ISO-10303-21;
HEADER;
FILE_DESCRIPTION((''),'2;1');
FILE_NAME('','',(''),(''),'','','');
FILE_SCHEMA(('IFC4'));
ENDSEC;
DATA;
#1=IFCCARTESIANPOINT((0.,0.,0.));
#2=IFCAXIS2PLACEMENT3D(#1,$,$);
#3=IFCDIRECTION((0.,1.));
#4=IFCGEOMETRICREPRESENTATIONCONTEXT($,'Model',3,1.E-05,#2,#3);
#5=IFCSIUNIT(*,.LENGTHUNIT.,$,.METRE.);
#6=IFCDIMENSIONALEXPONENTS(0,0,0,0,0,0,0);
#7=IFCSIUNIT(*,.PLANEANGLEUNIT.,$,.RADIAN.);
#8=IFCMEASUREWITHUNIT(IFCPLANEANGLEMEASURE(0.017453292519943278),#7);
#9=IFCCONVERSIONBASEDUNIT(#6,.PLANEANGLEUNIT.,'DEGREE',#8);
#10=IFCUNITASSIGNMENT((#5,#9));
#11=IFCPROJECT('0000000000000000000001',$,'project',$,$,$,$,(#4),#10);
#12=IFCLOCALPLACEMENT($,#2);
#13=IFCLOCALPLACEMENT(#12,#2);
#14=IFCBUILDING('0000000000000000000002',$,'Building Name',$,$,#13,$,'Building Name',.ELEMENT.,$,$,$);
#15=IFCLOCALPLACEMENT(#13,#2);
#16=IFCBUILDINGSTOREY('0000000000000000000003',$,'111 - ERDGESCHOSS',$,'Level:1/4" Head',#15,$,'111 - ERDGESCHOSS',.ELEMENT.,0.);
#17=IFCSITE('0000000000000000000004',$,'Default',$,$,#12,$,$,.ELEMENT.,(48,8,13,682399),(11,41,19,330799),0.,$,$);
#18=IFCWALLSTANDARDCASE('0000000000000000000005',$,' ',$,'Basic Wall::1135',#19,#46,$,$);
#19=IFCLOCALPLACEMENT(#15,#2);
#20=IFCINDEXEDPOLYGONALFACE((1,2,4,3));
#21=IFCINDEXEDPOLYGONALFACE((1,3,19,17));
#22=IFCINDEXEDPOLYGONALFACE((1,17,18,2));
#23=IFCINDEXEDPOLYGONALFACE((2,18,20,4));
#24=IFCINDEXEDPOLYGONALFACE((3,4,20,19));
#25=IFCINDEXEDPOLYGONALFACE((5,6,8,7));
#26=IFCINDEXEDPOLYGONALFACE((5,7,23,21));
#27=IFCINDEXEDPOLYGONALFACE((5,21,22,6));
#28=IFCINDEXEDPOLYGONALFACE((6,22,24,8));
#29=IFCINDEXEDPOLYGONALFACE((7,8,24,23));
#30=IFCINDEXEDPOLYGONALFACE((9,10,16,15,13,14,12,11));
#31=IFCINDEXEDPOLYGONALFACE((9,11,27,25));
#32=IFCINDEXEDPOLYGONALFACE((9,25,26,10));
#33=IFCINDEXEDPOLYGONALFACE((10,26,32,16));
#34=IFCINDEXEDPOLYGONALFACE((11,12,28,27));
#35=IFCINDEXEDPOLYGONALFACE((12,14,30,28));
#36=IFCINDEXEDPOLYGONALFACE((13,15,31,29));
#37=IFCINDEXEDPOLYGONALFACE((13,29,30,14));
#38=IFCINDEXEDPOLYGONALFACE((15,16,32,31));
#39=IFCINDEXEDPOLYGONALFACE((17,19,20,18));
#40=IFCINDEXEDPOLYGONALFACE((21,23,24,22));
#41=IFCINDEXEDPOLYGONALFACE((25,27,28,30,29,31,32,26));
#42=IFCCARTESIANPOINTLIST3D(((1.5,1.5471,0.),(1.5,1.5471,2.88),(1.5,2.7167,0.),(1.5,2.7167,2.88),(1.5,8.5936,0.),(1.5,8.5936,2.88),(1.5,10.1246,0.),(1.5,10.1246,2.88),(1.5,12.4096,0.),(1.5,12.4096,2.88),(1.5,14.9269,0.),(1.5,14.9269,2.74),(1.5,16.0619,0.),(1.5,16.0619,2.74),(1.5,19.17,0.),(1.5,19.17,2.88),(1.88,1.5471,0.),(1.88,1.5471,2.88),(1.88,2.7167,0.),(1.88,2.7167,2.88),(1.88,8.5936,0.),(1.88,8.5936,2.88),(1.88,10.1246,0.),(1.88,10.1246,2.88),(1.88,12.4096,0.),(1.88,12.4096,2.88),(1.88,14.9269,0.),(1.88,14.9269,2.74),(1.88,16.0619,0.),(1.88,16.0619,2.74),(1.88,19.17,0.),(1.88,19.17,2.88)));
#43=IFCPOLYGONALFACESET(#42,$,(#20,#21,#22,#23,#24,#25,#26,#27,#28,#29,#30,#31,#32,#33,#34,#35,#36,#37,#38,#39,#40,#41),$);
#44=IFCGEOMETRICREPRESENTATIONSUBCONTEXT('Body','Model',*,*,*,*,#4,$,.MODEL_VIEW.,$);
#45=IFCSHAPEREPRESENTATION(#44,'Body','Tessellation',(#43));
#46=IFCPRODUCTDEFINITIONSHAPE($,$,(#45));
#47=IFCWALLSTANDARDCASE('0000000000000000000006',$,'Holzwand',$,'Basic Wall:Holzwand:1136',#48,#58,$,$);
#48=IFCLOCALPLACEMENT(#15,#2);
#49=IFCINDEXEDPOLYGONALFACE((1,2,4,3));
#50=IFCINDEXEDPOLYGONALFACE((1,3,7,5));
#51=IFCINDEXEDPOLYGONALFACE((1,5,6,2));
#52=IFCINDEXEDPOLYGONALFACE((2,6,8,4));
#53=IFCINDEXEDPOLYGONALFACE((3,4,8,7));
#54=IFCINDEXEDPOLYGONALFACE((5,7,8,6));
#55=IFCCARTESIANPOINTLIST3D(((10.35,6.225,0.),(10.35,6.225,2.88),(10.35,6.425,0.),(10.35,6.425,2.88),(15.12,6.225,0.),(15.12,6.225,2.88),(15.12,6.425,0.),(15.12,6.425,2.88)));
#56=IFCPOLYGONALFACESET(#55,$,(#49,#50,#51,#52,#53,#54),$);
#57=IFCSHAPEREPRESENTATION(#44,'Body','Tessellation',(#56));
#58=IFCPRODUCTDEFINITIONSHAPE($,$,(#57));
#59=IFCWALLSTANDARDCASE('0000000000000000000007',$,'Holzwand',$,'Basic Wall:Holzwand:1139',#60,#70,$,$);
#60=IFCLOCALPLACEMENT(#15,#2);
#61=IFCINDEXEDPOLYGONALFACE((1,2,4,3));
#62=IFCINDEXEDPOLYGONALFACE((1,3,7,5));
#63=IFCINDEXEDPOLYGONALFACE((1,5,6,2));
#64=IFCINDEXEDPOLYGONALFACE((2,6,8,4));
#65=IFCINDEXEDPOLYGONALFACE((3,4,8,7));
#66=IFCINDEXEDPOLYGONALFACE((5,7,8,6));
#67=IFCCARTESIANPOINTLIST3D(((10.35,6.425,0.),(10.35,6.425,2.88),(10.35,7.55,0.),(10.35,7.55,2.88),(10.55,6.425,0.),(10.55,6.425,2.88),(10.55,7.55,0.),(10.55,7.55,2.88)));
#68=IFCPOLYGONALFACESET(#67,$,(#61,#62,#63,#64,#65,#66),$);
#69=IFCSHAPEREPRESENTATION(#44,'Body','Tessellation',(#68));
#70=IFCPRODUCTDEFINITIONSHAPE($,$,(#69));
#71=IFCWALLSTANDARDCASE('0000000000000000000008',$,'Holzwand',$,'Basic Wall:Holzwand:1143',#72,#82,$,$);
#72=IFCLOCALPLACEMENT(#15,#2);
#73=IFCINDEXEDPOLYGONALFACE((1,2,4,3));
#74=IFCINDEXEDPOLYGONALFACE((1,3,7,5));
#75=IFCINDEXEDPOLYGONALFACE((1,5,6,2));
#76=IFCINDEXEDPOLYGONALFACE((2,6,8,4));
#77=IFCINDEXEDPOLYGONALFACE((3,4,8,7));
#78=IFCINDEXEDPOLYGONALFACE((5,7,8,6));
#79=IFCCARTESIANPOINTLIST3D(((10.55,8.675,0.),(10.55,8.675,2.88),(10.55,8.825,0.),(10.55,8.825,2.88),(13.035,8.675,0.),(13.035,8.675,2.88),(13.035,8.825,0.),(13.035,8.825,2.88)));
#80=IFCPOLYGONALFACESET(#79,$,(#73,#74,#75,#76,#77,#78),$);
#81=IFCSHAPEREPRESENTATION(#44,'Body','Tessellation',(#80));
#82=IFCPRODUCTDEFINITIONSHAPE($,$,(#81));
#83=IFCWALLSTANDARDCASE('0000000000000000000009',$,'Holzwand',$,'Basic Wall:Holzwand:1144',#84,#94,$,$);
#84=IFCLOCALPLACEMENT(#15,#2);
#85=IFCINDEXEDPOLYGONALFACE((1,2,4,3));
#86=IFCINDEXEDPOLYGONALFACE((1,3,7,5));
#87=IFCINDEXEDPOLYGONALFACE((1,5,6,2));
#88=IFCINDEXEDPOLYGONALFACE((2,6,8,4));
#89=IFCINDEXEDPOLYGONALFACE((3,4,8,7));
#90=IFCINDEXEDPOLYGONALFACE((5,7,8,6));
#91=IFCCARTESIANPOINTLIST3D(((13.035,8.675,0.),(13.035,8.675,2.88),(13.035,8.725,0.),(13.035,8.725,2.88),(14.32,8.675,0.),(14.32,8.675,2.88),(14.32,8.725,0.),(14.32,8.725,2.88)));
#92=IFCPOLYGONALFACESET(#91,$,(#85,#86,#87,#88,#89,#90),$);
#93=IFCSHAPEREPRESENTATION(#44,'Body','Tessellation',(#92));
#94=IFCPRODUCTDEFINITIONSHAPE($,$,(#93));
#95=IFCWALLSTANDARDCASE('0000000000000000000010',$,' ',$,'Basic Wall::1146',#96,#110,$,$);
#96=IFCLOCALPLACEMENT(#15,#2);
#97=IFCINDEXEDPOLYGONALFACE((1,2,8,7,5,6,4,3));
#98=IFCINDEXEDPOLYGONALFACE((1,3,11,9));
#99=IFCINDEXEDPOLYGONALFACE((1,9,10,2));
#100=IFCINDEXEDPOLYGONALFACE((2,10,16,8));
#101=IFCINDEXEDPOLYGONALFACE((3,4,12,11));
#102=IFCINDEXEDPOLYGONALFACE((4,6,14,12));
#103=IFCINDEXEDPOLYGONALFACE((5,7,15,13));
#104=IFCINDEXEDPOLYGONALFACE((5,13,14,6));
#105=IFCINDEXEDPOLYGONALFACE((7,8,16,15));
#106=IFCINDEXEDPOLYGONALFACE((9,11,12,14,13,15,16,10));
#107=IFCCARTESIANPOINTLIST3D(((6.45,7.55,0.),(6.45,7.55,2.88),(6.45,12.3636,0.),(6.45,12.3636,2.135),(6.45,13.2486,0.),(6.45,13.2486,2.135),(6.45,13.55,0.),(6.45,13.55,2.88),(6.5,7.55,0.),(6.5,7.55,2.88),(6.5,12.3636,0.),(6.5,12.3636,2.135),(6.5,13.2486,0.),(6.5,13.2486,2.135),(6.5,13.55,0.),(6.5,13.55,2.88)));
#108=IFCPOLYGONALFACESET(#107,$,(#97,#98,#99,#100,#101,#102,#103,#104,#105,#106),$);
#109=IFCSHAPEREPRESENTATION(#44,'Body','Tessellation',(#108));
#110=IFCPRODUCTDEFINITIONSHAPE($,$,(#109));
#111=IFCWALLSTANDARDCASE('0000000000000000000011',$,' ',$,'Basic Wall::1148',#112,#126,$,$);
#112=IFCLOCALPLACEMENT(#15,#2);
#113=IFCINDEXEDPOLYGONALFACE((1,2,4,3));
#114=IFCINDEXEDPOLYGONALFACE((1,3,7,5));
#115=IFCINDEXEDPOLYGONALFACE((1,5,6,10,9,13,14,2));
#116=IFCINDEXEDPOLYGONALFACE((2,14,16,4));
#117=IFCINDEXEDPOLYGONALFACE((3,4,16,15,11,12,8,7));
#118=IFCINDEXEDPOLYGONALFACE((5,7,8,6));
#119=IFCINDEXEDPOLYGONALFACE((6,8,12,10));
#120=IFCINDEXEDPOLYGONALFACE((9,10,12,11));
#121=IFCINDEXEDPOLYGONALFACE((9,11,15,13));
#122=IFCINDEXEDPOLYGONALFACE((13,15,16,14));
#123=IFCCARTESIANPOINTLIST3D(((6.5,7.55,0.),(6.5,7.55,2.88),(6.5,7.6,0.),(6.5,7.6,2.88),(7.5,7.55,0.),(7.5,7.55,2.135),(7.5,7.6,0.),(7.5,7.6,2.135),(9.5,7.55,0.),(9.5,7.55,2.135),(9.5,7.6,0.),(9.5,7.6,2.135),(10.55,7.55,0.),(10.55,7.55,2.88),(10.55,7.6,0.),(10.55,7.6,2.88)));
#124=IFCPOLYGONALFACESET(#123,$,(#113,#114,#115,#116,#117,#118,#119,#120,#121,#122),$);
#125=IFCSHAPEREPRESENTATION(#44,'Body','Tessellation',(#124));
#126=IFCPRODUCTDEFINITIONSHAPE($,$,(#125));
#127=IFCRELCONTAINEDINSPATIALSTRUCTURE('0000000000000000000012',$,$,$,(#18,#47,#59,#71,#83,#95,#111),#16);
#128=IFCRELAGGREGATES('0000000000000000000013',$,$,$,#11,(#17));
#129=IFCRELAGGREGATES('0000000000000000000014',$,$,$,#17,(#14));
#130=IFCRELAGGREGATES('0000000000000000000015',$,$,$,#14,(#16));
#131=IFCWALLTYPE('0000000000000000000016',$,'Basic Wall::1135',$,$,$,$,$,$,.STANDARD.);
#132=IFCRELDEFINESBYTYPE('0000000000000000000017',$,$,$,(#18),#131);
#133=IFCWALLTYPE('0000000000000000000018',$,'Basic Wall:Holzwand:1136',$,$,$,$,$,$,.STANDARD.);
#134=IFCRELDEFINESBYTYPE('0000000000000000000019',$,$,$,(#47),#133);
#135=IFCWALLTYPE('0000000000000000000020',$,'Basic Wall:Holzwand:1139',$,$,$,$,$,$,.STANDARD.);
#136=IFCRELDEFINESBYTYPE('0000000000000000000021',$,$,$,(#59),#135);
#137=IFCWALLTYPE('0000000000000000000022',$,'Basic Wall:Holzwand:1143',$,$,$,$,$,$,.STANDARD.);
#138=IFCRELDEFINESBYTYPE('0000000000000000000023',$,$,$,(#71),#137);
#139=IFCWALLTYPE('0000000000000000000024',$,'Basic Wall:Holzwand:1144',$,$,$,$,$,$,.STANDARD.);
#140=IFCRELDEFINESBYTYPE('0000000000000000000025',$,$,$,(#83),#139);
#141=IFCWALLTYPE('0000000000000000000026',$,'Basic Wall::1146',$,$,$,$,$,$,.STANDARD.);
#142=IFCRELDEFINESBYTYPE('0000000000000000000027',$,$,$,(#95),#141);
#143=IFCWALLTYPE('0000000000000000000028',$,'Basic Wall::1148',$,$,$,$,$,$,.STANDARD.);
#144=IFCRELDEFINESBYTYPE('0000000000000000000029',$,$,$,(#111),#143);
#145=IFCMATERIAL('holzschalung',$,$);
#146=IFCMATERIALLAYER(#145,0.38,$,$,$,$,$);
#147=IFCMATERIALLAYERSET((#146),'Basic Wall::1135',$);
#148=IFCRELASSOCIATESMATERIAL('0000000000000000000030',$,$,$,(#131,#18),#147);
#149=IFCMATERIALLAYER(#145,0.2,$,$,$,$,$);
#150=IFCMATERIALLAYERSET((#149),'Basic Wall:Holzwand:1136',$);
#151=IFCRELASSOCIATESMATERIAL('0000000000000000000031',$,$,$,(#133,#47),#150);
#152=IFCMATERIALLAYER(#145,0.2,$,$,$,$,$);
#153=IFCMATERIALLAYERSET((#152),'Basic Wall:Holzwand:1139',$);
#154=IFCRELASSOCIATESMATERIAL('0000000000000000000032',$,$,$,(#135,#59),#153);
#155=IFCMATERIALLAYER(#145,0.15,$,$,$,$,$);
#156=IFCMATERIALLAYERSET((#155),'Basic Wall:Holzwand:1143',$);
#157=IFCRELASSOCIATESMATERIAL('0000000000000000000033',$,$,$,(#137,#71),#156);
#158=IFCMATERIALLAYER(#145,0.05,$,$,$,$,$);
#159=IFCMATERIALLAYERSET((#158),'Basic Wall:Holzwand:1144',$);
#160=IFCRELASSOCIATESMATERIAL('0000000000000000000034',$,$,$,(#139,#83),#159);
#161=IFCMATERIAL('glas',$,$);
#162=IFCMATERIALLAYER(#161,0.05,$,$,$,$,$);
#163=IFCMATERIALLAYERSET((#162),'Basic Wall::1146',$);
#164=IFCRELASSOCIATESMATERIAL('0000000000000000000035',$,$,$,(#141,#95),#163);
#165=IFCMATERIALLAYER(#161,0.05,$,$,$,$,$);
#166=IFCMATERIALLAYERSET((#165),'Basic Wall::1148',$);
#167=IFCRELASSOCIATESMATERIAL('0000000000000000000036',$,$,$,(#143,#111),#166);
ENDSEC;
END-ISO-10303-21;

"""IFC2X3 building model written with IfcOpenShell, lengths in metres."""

from ifc_helpers import new_model, entity, si_unit, converted_unit, direction, frame, frame_2d, origin, place, context, subcontext, project, spatial, rectangle, extrude, material, layer, layer_set, layer_usage, type_object, element, save


model = new_model("IFC2X3")

# Units and contexts
model_context = context("Model", 3, precision=1e-05, world=origin(), true_north=direction((0.0, 1.0)))
body_context = subcontext(model_context, "Body", "Model", "MODEL_VIEW")
ifc_project = project(units=[si_unit("LENGTHUNIT", "METRE"), converted_unit("PLANEANGLEUNIT", "DEGREE", entity("IfcPlaneAngleMeasure", 0.017453292519943278), si_unit("PLANEANGLEUNIT", "RADIAN"), dimensions=[0, 0, 0, 0, 0, 0, 0])], contexts=[model_context])

# Site, building, storey
site_placement = place(None, origin())
site = spatial("IfcSite", under=ifc_project, at=site_placement, Name="Default", CompositionType="ELEMENT", RefLatitude=(48, 8, 13, 682399), RefLongitude=(11, 41, 19, 330799), RefElevation=0.0)
building_placement = place(site_placement, origin())
building = spatial("IfcBuilding", under=site, at=building_placement, Name="Building Name", LongName="Building Name", CompositionType="ELEMENT")
storey_placement = place(building_placement, origin())
storey = spatial("IfcBuildingStorey", under=building, at=storey_placement, Name="111 - ERDGESCHOSS", ObjectType="Level:1/4\" Head", LongName="111 - ERDGESCHOSS", CompositionType="ELEMENT", Elevation=0.0)

# Wall, openings
ifc_material_1 = material(Name="holzschalung")
ifc_layer_1 = layer(ifc_material_1, 0.38)
ifc_layer_set_1 = layer_set([ifc_layer_1], Name="Basic Wall::1135")
ifc_layer_usage_1 = layer_usage(ifc_layer_set_1, "AXIS2", "NEGATIVE", 0.19)
wall_type_1 = type_object("IfcWallType", Name="Basic Wall::1135", PredefinedType="STANDARD", material=ifc_layer_set_1)
wall_1_placement = place(storey_placement, frame((1.69, 1.5471, 0.0), z_axis=(0.0, 0.0, 1.0), x_axis=(0.0, 1.0, 0.0)))
wall_1 = element("IfcWallStandardCase", 1, at=wall_1_placement, inside=storey, type_object=wall_type_1, material=ifc_layer_usage_1, Name=" ", ObjectType="Basic Wall::1135", context=body_context, shape_type="SweptSolid", body=[
    extrude(rectangle(XDim=17.6229, YDim=0.38, at=frame_2d((8.8114, 0.0), x_axis=(-1.0, 0.0))), origin(), (0.0, 0.0, 1.0), 2.88),
])
opening_1_placement = place(wall_1_placement, origin())
element("IfcOpeningElement", 2, at=opening_1_placement, cuts=wall_1, ObjectType="Opening", context=body_context, shape_type="SweptSolid", body=[
    extrude(rectangle(XDim=2.88, YDim=1.135, at=frame_2d((0.0, 0.0), x_axis=(0.0, 1.0))), frame((9.145, -0.19, 1.44), z_axis=(0.0, 1.0, 0.0), x_axis=(-1.0, 0.0, 0.0)), (0.0, 0.0, 1.0), 0.38),
])
opening_2_placement = place(wall_1_placement, origin())
element("IfcOpeningElement", 3, at=opening_2_placement, cuts=wall_1, ObjectType="Opening", context=body_context, shape_type="SweptSolid", body=[
    extrude(rectangle(XDim=2.88, YDim=1.135, at=frame_2d((0.0, 0.0), x_axis=(0.0, 1.0))), frame((6.4789, -0.19, 1.44), z_axis=(0.0, 1.0, 0.0), x_axis=(-1.0, 0.0, 0.0)), (0.0, 0.0, 1.0), 0.38),
])
opening_3_placement = place(wall_1_placement, origin())
element("IfcOpeningElement", 4, at=opening_3_placement, cuts=wall_1, ObjectType="Opening", context=body_context, shape_type="SweptSolid", body=[
    extrude(rectangle(XDim=2.88, YDim=1.135, at=frame_2d((0.0, 0.0), x_axis=(0.0, 1.0))), frame((1.7371, -0.19, 1.44), z_axis=(0.0, 1.0, 0.0), x_axis=(-1.0, 0.0, 0.0)), (0.0, 0.0, 1.0), 0.38),
])
opening_4_placement = place(wall_1_placement, origin())
element("IfcOpeningElement", 5, at=opening_4_placement, cuts=wall_1, ObjectType="Opening", context=body_context, shape_type="SweptSolid", body=[
    extrude(rectangle(XDim=2.88, YDim=1.15, at=frame_2d((0.0, 0.0), x_axis=(0.0, 1.0))), frame((10.2875, -0.19, 1.44), z_axis=(0.0, 1.0, 0.0), x_axis=(-1.0, 0.0, 0.0)), (0.0, 0.0, 1.0), 0.38),
])
opening_5_placement = place(wall_1_placement, origin())
element("IfcOpeningElement", 6, at=opening_5_placement, cuts=wall_1, ObjectType="Opening", context=body_context, shape_type="SweptSolid", body=[
    extrude(rectangle(XDim=2.74, YDim=1.135, at=frame_2d((0.0, 0.0), x_axis=(0.0, 1.0))), frame((13.9473, -0.19, 1.37), z_axis=(0.0, 1.0, 0.0), x_axis=(-1.0, 0.0, 0.0)), (0.0, 0.0, 1.0), 0.38),
])
opening_6_placement = place(wall_1_placement, origin())
element("IfcOpeningElement", 7, at=opening_6_placement, cuts=wall_1, ObjectType="Opening", context=body_context, shape_type="SweptSolid", body=[
    extrude(rectangle(XDim=2.88, YDim=3.608, at=frame_2d((0.0, 0.0), x_axis=(0.0, 1.0))), frame((4.1074, -0.19, 1.44), z_axis=(0.0, 1.0, 0.0), x_axis=(-1.0, 0.0, 0.0)), (0.0, 0.0, 1.0), 0.38),
])

# Walls
ifc_layer_2 = layer(ifc_material_1, 0.2)
ifc_layer_set_2 = layer_set([ifc_layer_2], Name="Basic Wall:Holzwand:1136")
ifc_layer_usage_2 = layer_usage(ifc_layer_set_2, "AXIS2", "NEGATIVE", 0.1)
wall_type_2 = type_object("IfcWallType", Name="Basic Wall:Holzwand:1136", PredefinedType="STANDARD", material=ifc_layer_set_2)
wall_2_placement = place(storey_placement, frame((15.12, 6.325, 0.0), z_axis=(0.0, 0.0, 1.0), x_axis=(-1.0, 0.0, 0.0)))
element("IfcWallStandardCase", 8, at=wall_2_placement, inside=storey, type_object=wall_type_2, material=ifc_layer_usage_2, Name="Holzwand", ObjectType="Basic Wall:Holzwand:1136", context=body_context, shape_type="SweptSolid", body=[
    extrude(rectangle(XDim=4.77, YDim=0.2, at=frame_2d((2.385, 0.0), x_axis=(-1.0, 0.0))), origin(), (0.0, 0.0, 1.0), 2.88),
])
ifc_layer_3 = layer(ifc_material_1, 0.2)
ifc_layer_set_3 = layer_set([ifc_layer_3], Name="Basic Wall:Holzwand:1139")
ifc_layer_usage_3 = layer_usage(ifc_layer_set_3, "AXIS2", "NEGATIVE", 0.1)
wall_type_3 = type_object("IfcWallType", Name="Basic Wall:Holzwand:1139", PredefinedType="STANDARD", material=ifc_layer_set_3)
wall_3_placement = place(storey_placement, frame((10.45, 7.55, 0.0), z_axis=(0.0, 0.0, 1.0), x_axis=(0.0, -1.0, 0.0)))
element("IfcWallStandardCase", 9, at=wall_3_placement, inside=storey, type_object=wall_type_3, material=ifc_layer_usage_3, Name="Holzwand", ObjectType="Basic Wall:Holzwand:1139", context=body_context, shape_type="SweptSolid", body=[
    extrude(rectangle(XDim=1.125, YDim=0.2, at=frame_2d((0.5625, 0.0), x_axis=(-1.0, 0.0))), origin(), (0.0, 0.0, 1.0), 2.88),
])
ifc_layer_4 = layer(ifc_material_1, 0.15)
ifc_layer_set_4 = layer_set([ifc_layer_4], Name="Basic Wall:Holzwand:1143")
ifc_layer_usage_4 = layer_usage(ifc_layer_set_4, "AXIS2", "NEGATIVE", 0.075)
wall_type_4 = type_object("IfcWallType", Name="Basic Wall:Holzwand:1143", PredefinedType="STANDARD", material=ifc_layer_set_4)
wall_4_placement = place(storey_placement, frame((13.035, 8.75, 0.0), z_axis=(0.0, 0.0, 1.0), x_axis=(-1.0, 0.0, 0.0)))
element("IfcWallStandardCase", 10, at=wall_4_placement, inside=storey, type_object=wall_type_4, material=ifc_layer_usage_4, Name="Holzwand", ObjectType="Basic Wall:Holzwand:1143", context=body_context, shape_type="SweptSolid", body=[
    extrude(rectangle(XDim=2.485, YDim=0.15, at=frame_2d((1.2425, 0.0), x_axis=(-1.0, 0.0))), origin(), (0.0, 0.0, 1.0), 2.88),
])
ifc_layer_5 = layer(ifc_material_1, 0.05)
ifc_layer_set_5 = layer_set([ifc_layer_5], Name="Basic Wall:Holzwand:1144")
ifc_layer_usage_5 = layer_usage(ifc_layer_set_5, "AXIS2", "NEGATIVE", 0.025)
wall_type_5 = type_object("IfcWallType", Name="Basic Wall:Holzwand:1144", PredefinedType="STANDARD", material=ifc_layer_set_5)
wall_5_placement = place(storey_placement, frame((13.035, 8.7, 0.0)))
element("IfcWallStandardCase", 11, at=wall_5_placement, inside=storey, type_object=wall_type_5, material=ifc_layer_usage_5, Name="Holzwand", ObjectType="Basic Wall:Holzwand:1144", context=body_context, shape_type="SweptSolid", body=[
    extrude(rectangle(XDim=1.285, YDim=0.05, at=frame_2d((0.6425, 0.0), x_axis=(-1.0, 0.0))), origin(), (0.0, 0.0, 1.0), 2.88),
])

# Walls, openings
ifc_material_2 = material(Name="glas")
ifc_layer_6 = layer(ifc_material_2, 0.05)
ifc_layer_set_6 = layer_set([ifc_layer_6], Name="Basic Wall::1146")
ifc_layer_usage_6 = layer_usage(ifc_layer_set_6, "AXIS2", "NEGATIVE", 0.025)
wall_type_6 = type_object("IfcWallType", Name="Basic Wall::1146", PredefinedType="STANDARD", material=ifc_layer_set_6)
wall_6_placement = place(storey_placement, frame((6.475, 7.55, 0.0), z_axis=(0.0, 0.0, 1.0), x_axis=(0.0, 1.0, 0.0)))
wall_6 = element("IfcWallStandardCase", 12, at=wall_6_placement, inside=storey, type_object=wall_type_6, material=ifc_layer_usage_6, Name=" ", ObjectType="Basic Wall::1146", context=body_context, shape_type="SweptSolid", body=[
    extrude(rectangle(XDim=6.0, YDim=0.05, at=frame_2d((3.0, 0.0), x_axis=(-1.0, 0.0))), origin(), (0.0, 0.0, 1.0), 2.88),
])
opening_7_placement = place(wall_6_placement, frame((-7.55, 6.475, 0.0), z_axis=(0.0, 0.0, 1.0), x_axis=(0.0, -1.0, 0.0)))
element("IfcOpeningElement", 13, at=opening_7_placement, cuts=wall_6, ObjectType="Opening", context=body_context, shape_type="SweptSolid", body=[
    extrude(rectangle(XDim=2.135, YDim=0.885, at=frame_2d((0.0, 0.0), x_axis=(0.0, 1.0))), frame((6.5005, 12.8061, 1.0675), z_axis=(-1.0, 0.0, 0.0), x_axis=(0.0, -1.0, 0.0)), (0.0, 0.0, 1.0), 0.051),
])
ifc_layer_7 = layer(ifc_material_2, 0.05)
ifc_layer_set_7 = layer_set([ifc_layer_7], Name="Basic Wall::1148")
ifc_layer_usage_7 = layer_usage(ifc_layer_set_7, "AXIS2", "NEGATIVE", 0.025)
wall_type_7 = type_object("IfcWallType", Name="Basic Wall::1148", PredefinedType="STANDARD", material=ifc_layer_set_7)
wall_7_placement = place(storey_placement, frame((10.55, 7.575, 0.0), z_axis=(0.0, 0.0, 1.0), x_axis=(-1.0, 0.0, 0.0)))
wall_7 = element("IfcWallStandardCase", 14, at=wall_7_placement, inside=storey, type_object=wall_type_7, material=ifc_layer_usage_7, Name=" ", ObjectType="Basic Wall::1148", context=body_context, shape_type="SweptSolid", body=[
    extrude(rectangle(XDim=4.05, YDim=0.05, at=frame_2d((2.025, 0.0), x_axis=(1.0, 0.0))), origin(), (0.0, 0.0, 1.0), 2.88),
])
opening_8_placement = place(wall_7_placement, frame((10.55, 7.575, 0.0), z_axis=(0.0, 0.0, 1.0), x_axis=(-1.0, 0.0, 0.0)))
element("IfcOpeningElement", 15, at=opening_8_placement, cuts=wall_7, ObjectType="Opening", context=body_context, shape_type="SweptSolid", body=[
    extrude(rectangle(XDim=2.135, YDim=2.0, at=frame_2d((0.0, 0.0), x_axis=(0.0, 1.0))), frame((8.5, 7.6005, 1.0675), z_axis=(0.0, -1.0, 0.0), x_axis=(1.0, 0.0, 0.0)), (0.0, 0.0, 1.0), 0.051),
])

save(model, "model.ifc")
